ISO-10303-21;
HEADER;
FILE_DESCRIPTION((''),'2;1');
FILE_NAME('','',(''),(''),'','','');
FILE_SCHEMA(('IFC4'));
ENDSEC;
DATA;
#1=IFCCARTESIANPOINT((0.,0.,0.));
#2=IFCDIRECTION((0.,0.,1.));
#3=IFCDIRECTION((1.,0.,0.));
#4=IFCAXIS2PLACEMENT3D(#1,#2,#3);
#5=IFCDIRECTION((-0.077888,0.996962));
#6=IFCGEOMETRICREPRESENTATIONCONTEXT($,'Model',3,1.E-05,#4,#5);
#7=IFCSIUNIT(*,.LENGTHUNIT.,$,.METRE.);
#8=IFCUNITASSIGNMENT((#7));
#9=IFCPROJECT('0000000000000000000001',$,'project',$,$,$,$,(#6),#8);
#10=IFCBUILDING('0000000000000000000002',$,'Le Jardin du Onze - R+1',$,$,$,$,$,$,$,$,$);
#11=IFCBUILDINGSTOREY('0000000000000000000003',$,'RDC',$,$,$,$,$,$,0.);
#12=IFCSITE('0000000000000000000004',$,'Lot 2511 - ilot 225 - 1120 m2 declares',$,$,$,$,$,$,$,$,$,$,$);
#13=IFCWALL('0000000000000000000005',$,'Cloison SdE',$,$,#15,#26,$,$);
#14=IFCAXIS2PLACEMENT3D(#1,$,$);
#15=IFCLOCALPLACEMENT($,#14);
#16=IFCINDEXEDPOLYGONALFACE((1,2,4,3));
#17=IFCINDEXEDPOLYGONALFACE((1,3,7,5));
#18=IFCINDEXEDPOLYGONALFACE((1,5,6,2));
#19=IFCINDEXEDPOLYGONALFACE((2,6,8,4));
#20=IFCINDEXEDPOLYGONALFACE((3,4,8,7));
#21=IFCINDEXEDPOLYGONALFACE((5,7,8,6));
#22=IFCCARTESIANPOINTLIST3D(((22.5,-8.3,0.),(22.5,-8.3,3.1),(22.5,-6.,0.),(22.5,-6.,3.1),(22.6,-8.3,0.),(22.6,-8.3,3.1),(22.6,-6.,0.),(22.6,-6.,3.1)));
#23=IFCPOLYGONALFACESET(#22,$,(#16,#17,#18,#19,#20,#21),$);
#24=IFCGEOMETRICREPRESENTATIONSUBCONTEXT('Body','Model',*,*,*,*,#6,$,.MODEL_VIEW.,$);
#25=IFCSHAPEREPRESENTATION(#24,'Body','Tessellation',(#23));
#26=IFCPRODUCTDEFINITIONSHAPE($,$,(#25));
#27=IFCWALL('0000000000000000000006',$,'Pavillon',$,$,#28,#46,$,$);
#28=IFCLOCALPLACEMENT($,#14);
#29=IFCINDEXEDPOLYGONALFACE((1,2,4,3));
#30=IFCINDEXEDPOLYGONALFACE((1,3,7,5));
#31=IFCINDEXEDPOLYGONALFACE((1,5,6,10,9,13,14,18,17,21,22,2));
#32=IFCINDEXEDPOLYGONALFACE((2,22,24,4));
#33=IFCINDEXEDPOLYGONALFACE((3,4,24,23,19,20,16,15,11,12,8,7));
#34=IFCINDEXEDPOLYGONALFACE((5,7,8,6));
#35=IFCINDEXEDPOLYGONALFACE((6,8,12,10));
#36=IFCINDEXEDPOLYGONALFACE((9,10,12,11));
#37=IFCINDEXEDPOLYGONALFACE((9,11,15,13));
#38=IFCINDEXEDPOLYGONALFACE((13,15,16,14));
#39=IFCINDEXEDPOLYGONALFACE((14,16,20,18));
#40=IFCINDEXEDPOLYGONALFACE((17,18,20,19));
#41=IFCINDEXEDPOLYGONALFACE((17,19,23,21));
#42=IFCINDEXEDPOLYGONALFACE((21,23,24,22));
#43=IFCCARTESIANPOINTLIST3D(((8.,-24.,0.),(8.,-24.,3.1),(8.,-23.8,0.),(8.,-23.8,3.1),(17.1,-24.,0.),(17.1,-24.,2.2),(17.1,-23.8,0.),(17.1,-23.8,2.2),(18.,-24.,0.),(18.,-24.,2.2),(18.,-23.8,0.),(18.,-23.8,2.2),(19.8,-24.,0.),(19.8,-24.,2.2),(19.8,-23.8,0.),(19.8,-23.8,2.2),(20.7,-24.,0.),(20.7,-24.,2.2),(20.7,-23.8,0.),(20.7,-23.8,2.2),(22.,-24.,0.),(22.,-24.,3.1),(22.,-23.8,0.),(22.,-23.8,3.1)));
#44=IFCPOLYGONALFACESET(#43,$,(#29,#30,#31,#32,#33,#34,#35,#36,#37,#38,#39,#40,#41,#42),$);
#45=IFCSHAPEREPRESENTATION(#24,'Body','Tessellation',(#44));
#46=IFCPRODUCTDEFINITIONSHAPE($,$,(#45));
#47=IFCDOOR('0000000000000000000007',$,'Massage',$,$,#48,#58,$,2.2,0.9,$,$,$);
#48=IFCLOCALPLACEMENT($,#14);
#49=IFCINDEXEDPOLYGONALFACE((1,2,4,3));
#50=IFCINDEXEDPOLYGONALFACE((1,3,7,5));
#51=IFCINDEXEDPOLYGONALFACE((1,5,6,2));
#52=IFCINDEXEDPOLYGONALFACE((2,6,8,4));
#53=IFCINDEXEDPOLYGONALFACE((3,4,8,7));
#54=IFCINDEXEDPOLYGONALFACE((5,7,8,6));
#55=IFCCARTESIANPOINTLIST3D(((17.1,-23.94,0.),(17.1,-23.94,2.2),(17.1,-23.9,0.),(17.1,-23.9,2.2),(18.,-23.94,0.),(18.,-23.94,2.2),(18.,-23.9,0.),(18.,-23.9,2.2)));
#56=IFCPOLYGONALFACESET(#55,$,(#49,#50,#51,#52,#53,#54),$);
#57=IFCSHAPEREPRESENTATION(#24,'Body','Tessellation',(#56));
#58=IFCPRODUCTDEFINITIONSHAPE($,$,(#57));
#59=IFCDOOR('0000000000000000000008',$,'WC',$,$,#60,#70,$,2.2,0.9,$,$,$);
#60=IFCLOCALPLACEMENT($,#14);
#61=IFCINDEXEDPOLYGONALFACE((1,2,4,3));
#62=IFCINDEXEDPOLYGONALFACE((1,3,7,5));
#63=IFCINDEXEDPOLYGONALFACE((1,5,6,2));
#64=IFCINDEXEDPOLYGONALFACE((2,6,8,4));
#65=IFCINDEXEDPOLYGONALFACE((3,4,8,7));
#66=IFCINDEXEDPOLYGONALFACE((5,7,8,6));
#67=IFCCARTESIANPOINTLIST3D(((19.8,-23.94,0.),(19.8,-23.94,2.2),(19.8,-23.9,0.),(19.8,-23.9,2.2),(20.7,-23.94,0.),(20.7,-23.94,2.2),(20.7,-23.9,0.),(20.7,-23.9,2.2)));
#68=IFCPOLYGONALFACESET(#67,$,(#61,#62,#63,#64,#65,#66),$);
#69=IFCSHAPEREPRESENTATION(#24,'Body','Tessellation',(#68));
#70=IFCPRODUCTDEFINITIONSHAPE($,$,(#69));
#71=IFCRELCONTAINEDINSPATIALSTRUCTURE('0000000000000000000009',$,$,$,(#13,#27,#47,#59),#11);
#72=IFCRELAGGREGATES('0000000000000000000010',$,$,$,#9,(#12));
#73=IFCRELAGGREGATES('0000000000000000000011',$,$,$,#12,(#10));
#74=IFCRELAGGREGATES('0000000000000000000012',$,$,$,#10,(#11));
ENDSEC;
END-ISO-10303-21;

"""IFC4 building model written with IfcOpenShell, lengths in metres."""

from ifc_helpers import new_model, si_unit, direction, origin, origin_with_axes, place, context, subcontext, project, spatial, polyline, outline, extrude, element, fill, save


model = new_model("IFC4")

# Units and contexts
model_context = context("Model", 3, precision=1e-05, world=origin_with_axes(), true_north=direction((-0.077888, 0.996962)))
body_context = subcontext(model_context, "Body", "Model", "MODEL_VIEW")
ifc_project = project(units=[si_unit("LENGTHUNIT", "METRE")], contexts=[model_context])

# Site, building, storey
site = spatial("IfcSite", under=ifc_project, Name="Lot 2511 - ilot 225 - 1120 m2 declares")
building = spatial("IfcBuilding", under=site, Name="Le Jardin du Onze - R+1")
storey = spatial("IfcBuildingStorey", under=building, Name="RDC", Elevation=0.0)

# Wall
wall_1_placement = place(None, origin_with_axes())
element("IfcWall", 1, at=wall_1_placement, inside=storey, Name="Cloison SdE", context=body_context, shape_type="SweptSolid", body=[
    extrude(outline(polyline([(22.6, -8.3), (22.6, -6.0), (22.5, -6.0), (22.5, -8.3), (22.6, -8.3)])), origin(), (0.0, 0.0, 1.0), 3.1),
])

# Wall, openings, doors
wall_2_placement = place(None, origin_with_axes())
wall_2 = element("IfcWall", 2, at=wall_2_placement, inside=storey, Name="Pavillon", context=body_context, shape_type="SweptSolid", body=[
    extrude(outline(polyline([(22.0, -24.0), (22.0, -23.8), (8.0, -23.8), (8.0, -24.0), (22.0, -24.0)])), origin(), (0.0, 0.0, 1.0), 3.1),
])
opening_1_placement = place(None, origin_with_axes())
opening_1 = element("IfcOpeningElement", 3, at=opening_1_placement, cuts=wall_2, context=body_context, shape_type="SweptSolid", body=[
    extrude(outline(polyline([(18.0, -24.04), (18.0, -23.76), (17.1, -23.76), (17.1, -24.04), (18.0, -24.04)])), origin(), (0.0, 0.0, 1.0), 2.2),
])
opening_2_placement = place(None, origin_with_axes())
opening_2 = element("IfcOpeningElement", 4, at=opening_2_placement, cuts=wall_2, context=body_context, shape_type="SweptSolid", body=[
    extrude(outline(polyline([(20.7, -24.04), (20.7, -23.76), (19.8, -23.76), (19.8, -24.04), (20.7, -24.04)])), origin(), (0.0, 0.0, 1.0), 2.2),
])
door_1_placement = place(None, origin_with_axes())
door_1 = element("IfcDoor", 5, at=door_1_placement, inside=storey, Name="Massage", OverallHeight=2.2, OverallWidth=0.9, context=body_context, shape_type="SweptSolid", body=[
    extrude(outline(polyline([(18.0, -23.94), (18.0, -23.9), (17.1, -23.9), (17.1, -23.94), (18.0, -23.94)])), origin(), (0.0, 0.0, 1.0), 2.2),
])
fill(opening_1, door_1)
door_2_placement = place(None, origin_with_axes())
door_2 = element("IfcDoor", 6, at=door_2_placement, inside=storey, Name="WC", OverallHeight=2.2, OverallWidth=0.9, context=body_context, shape_type="SweptSolid", body=[
    extrude(outline(polyline([(20.7, -23.94), (20.7, -23.9), (19.8, -23.9), (19.8, -23.94), (20.7, -23.94)])), origin(), (0.0, 0.0, 1.0), 2.2),
])
fill(opening_2, door_2)

save(model, "model.ifc")
